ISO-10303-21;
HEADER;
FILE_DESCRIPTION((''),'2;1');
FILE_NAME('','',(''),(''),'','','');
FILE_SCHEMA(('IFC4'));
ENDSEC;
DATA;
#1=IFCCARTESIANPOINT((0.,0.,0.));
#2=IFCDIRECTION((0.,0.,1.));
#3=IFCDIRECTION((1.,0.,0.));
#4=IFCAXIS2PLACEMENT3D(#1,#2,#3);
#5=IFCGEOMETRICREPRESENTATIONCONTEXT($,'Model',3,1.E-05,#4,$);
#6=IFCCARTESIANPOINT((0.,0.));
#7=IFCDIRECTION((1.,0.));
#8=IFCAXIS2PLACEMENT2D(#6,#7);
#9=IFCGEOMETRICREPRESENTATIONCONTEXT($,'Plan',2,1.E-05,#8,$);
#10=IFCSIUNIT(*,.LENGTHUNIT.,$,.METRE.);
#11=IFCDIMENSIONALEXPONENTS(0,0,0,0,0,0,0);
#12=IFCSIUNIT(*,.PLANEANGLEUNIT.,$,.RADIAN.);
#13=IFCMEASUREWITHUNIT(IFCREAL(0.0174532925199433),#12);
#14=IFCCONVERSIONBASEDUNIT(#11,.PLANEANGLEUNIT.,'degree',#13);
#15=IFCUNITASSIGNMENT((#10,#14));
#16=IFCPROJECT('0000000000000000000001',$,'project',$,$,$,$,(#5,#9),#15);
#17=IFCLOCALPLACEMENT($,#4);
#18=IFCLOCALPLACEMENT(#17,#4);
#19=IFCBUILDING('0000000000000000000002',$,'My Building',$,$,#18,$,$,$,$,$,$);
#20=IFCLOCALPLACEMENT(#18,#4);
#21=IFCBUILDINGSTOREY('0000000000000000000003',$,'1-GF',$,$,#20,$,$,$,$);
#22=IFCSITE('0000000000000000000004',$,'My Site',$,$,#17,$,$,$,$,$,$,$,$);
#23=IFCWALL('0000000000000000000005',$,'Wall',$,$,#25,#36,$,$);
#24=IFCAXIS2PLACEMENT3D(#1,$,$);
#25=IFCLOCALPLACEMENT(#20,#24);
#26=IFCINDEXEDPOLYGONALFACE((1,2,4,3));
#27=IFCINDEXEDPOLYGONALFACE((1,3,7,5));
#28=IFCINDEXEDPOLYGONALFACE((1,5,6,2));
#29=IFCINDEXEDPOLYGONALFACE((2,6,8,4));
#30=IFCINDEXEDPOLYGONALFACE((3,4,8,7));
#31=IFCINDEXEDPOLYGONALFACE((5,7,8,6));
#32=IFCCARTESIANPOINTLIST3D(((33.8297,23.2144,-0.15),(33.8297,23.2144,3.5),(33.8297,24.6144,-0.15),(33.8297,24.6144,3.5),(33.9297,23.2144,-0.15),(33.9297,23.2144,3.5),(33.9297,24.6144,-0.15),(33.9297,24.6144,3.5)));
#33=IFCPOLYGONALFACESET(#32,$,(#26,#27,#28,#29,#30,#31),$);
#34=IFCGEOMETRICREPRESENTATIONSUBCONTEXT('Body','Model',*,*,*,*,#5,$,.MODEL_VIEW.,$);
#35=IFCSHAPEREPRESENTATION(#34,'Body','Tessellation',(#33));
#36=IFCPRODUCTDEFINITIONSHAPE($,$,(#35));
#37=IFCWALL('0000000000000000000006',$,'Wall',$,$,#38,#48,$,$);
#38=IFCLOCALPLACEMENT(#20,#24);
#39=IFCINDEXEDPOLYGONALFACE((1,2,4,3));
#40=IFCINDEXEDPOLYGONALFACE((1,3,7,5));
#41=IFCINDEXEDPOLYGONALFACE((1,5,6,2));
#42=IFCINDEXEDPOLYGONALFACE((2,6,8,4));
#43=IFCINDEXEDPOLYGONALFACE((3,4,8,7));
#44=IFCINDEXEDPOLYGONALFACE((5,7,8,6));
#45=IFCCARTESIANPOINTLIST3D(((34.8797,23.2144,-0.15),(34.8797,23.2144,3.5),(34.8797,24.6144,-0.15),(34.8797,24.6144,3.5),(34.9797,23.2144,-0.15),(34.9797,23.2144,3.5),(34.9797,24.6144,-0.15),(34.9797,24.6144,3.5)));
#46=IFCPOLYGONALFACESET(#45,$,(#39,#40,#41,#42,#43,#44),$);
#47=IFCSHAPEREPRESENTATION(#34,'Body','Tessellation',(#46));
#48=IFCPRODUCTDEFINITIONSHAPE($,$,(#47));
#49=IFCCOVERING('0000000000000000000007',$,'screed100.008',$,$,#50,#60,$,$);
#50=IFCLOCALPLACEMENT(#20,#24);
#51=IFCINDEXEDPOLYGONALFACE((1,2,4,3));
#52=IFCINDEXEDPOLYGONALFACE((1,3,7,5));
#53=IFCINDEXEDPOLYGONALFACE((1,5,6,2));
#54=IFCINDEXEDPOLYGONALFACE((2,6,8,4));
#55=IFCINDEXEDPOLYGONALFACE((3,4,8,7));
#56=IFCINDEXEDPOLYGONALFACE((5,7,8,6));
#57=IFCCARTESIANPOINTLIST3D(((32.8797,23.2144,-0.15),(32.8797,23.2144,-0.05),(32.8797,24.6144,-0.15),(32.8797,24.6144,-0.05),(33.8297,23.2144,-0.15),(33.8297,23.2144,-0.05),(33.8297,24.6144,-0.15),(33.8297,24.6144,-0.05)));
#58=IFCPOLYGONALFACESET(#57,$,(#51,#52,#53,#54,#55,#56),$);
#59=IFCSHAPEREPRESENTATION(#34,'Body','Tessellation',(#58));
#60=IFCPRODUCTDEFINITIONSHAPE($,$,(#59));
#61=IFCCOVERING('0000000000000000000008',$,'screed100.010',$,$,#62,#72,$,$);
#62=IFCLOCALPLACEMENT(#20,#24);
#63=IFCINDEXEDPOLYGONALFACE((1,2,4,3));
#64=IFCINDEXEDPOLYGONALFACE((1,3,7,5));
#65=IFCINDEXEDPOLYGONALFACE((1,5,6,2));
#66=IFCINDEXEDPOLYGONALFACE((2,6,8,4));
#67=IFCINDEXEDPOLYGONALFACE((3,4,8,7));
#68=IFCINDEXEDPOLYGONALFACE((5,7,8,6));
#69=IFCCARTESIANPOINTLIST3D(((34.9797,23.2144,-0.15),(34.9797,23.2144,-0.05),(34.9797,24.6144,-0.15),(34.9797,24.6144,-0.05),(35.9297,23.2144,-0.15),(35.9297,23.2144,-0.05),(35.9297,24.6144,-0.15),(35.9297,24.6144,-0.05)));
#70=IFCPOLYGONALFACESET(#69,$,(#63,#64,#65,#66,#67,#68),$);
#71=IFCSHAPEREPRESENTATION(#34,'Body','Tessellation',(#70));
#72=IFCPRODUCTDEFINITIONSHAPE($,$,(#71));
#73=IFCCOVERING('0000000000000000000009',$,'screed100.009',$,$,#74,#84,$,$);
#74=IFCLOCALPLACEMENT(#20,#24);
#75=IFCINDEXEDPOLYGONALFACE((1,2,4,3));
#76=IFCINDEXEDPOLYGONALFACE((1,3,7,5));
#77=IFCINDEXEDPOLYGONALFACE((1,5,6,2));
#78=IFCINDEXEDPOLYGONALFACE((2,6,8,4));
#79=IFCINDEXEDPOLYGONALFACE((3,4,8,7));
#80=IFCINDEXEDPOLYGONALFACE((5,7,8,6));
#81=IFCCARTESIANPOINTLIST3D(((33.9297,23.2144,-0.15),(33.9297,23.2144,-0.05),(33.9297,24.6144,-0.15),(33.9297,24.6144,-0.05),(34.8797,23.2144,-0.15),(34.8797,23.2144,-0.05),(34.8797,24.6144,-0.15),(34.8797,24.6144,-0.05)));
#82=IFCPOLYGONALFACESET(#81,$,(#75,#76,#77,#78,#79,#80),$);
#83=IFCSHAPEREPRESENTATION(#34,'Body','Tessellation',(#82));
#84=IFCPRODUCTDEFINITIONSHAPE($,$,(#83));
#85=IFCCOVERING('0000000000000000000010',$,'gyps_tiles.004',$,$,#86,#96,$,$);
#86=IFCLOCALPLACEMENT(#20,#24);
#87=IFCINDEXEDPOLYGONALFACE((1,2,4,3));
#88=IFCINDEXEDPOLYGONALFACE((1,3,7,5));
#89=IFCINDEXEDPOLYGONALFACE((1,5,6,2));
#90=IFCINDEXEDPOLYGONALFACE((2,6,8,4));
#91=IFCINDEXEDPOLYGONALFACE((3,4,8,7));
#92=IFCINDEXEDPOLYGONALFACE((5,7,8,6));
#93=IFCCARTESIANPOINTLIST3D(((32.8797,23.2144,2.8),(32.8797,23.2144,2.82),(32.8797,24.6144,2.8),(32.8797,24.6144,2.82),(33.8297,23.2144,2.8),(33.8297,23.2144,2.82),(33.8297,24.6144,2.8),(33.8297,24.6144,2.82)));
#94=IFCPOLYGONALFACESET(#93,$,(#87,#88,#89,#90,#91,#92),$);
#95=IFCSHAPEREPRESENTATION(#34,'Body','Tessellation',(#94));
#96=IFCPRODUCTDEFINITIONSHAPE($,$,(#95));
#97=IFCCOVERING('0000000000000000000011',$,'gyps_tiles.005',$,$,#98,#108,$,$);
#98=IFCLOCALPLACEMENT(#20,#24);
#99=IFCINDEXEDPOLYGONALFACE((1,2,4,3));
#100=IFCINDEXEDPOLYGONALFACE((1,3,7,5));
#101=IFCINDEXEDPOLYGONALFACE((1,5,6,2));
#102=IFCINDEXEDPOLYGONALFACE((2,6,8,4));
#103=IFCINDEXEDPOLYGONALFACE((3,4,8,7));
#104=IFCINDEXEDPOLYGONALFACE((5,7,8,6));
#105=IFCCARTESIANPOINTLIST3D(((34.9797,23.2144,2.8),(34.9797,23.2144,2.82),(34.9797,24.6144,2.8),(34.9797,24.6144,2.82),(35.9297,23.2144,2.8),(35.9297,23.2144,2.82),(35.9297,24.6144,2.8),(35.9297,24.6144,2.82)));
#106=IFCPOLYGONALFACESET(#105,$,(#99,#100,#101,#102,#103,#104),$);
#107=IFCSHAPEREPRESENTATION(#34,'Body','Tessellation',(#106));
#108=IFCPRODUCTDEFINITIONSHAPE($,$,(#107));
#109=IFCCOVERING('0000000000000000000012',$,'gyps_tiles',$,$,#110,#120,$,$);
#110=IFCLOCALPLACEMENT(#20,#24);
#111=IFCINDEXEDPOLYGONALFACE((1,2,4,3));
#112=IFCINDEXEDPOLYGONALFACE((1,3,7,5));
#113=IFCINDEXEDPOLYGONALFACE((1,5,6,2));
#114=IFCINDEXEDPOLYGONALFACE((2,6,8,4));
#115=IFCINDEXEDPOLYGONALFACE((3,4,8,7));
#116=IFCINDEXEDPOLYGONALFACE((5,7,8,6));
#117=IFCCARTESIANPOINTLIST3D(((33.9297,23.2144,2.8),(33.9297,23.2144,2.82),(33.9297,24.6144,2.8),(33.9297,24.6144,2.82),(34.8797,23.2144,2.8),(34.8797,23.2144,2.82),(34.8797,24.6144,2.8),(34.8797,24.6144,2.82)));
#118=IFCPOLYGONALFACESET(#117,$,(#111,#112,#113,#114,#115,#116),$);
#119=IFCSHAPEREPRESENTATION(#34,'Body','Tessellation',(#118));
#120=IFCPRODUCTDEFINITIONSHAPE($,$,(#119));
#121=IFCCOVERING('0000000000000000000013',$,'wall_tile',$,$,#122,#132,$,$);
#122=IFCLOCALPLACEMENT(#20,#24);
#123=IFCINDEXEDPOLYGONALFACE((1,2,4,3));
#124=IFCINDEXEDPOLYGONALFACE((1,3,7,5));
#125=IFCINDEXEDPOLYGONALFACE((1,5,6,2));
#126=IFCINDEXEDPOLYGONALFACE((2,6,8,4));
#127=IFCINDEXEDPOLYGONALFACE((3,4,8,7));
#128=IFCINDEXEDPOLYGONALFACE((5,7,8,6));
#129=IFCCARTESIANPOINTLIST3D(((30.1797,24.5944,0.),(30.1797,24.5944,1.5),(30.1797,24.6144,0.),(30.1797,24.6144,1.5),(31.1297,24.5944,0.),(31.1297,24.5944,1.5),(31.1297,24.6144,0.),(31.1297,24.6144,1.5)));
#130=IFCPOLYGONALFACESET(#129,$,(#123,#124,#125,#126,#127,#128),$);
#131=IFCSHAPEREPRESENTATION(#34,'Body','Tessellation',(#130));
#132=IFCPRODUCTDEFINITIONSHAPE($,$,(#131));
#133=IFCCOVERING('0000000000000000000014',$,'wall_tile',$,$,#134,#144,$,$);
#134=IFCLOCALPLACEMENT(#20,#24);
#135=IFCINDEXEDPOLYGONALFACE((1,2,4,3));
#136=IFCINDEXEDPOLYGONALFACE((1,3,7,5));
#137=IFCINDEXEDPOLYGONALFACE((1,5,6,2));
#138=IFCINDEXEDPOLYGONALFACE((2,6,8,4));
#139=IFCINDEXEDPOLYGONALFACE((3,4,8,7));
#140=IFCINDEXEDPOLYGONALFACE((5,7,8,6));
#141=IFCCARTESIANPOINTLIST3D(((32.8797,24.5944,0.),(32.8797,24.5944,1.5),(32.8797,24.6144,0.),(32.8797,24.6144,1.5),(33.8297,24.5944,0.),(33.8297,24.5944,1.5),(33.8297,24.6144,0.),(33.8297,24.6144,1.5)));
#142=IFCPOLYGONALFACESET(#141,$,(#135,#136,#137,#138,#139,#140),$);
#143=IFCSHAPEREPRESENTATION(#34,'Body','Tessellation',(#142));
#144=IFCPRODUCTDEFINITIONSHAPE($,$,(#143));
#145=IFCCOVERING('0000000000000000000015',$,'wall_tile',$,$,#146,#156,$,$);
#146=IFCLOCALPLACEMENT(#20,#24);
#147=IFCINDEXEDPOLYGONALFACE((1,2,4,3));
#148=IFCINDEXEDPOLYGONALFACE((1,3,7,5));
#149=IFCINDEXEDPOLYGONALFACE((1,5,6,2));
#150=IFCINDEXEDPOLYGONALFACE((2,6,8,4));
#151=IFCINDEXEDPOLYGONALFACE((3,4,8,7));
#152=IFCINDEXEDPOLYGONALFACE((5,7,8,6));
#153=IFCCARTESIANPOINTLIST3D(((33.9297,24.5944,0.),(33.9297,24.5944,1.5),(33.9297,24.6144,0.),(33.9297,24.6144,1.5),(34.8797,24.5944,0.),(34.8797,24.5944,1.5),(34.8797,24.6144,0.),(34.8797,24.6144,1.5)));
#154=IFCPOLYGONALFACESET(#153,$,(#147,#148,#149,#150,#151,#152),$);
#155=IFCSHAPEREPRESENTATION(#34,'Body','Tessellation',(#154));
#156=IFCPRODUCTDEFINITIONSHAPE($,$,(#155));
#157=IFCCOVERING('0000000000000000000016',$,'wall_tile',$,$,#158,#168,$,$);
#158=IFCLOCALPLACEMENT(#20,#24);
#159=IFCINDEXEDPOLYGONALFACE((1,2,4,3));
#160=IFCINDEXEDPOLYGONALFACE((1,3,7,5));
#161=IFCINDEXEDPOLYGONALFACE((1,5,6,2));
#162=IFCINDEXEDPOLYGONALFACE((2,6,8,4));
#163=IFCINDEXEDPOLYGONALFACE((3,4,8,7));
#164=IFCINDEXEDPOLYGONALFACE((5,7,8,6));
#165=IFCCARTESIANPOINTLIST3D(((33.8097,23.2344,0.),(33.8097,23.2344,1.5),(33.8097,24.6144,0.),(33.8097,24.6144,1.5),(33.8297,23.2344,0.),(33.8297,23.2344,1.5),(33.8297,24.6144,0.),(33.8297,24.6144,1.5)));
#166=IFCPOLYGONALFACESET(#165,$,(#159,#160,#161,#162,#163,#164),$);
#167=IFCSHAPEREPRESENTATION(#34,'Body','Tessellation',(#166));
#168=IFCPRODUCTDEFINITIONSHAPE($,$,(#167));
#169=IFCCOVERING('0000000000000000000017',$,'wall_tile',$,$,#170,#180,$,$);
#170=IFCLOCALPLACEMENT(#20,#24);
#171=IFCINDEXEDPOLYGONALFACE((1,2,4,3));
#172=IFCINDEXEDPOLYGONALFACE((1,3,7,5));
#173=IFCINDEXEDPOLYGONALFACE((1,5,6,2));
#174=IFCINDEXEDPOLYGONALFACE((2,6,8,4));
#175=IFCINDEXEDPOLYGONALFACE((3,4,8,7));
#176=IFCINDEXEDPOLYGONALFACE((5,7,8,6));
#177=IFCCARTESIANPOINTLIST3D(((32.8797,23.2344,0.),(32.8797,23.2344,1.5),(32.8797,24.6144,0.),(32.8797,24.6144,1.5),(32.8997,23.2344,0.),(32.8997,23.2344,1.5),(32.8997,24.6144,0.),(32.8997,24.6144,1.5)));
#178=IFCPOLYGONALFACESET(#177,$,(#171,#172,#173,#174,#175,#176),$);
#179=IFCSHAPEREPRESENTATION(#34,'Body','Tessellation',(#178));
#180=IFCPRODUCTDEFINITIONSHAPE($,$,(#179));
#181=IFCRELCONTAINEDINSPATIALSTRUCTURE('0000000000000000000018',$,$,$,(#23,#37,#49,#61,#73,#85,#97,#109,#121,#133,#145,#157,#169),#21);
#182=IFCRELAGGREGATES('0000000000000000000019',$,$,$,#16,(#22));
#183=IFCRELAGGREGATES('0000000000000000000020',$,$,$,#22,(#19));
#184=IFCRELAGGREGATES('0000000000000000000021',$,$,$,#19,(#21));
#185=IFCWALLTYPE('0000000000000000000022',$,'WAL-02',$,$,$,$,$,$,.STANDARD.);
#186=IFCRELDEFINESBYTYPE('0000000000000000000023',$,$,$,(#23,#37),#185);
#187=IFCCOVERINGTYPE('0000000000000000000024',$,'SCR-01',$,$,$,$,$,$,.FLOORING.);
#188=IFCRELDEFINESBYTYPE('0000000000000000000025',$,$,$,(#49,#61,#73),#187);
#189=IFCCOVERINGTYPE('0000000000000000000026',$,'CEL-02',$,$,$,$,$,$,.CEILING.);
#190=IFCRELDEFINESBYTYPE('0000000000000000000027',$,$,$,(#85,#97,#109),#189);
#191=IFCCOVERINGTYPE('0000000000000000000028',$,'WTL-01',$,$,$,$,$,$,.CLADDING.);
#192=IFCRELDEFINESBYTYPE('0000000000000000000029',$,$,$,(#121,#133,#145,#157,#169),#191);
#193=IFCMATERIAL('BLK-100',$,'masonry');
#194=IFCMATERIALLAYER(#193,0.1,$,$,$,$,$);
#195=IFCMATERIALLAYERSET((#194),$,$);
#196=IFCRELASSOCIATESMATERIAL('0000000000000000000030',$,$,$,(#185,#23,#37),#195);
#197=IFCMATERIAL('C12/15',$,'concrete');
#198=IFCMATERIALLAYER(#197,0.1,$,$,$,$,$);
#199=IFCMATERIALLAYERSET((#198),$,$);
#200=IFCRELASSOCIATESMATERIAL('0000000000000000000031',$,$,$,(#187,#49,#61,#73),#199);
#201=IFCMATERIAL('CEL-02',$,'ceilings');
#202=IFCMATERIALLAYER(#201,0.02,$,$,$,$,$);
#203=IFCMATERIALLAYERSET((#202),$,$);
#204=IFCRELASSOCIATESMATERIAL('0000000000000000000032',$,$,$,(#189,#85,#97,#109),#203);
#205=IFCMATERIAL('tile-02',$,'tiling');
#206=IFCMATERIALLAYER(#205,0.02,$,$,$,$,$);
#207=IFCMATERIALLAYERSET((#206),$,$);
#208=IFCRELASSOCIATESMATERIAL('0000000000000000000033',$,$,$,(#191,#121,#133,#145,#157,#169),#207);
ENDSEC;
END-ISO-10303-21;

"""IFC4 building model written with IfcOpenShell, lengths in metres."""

from ifc_helpers import new_model, entity, si_unit, converted_unit, frame, origin_with_axes, origin_2d_with_axis, place, context, subcontext, project, spatial, line, indexed_curve, outline, extrude, material, layer, layer_set, layer_usage, type_object, element, save


model = new_model("IFC4")

# Units and contexts
model_context = context("Model", 3, precision=1e-05, world=origin_with_axes())
plan_context = context("Plan", 2, precision=1e-05, world=origin_2d_with_axis())
body_context_1 = subcontext(model_context, "Body", "Model", "MODEL_VIEW")
ifc_project = project(units=[si_unit("LENGTHUNIT", "METRE"), converted_unit("PLANEANGLEUNIT", "degree", entity("IfcReal", 0.0174532925199433), si_unit("PLANEANGLEUNIT", "RADIAN"), dimensions=[0, 0, 0, 0, 0, 0, 0])], contexts=[model_context, plan_context])

# Site, building, storey
site_placement = place(None, origin_with_axes())
site = spatial("IfcSite", under=ifc_project, at=site_placement, Name="My Site")
building_placement = place(site_placement, origin_with_axes())
building = spatial("IfcBuilding", under=site, at=building_placement, Name="My Building")
storey_placement = place(building_placement, origin_with_axes())
storey = spatial("IfcBuildingStorey", under=building, at=storey_placement, Name="1-GF")

# Shared definitions
ifc_material_1 = material(Name="BLK-100", Category="masonry")
ifc_layer_1 = layer(ifc_material_1, 0.1)
ifc_layer_set_1 = layer_set([ifc_layer_1])
wall_type = type_object("IfcWallType", Name="WAL-02", PredefinedType="STANDARD", material=ifc_layer_set_1)

# Walls
ifc_layer_usage_1 = layer_usage(ifc_layer_set_1, "AXIS2", "POSITIVE", 0.0)
wall_1_placement = place(storey_placement, frame((33.9297, 23.2144, -0.15), z_axis=(0.0, 0.0, 1.0), x_axis=(0.0, 1.0, 0.0)))
element("IfcWall", 1, at=wall_1_placement, inside=storey, type_object=wall_type, material=ifc_layer_usage_1, Name="Wall", context=body_context_1, shape_type="SweptSolid", body=[
    extrude(outline(indexed_curve([(0.0, 0.0), (0.0, 0.1), (1.4, 0.1), (1.4, 0.0), (0.0, 0.0)], self_intersect=False)), origin_with_axes(), (0.0, 0.0, 1.0), 3.65),
])
ifc_layer_usage_2 = layer_usage(ifc_layer_set_1, "AXIS2", "POSITIVE", 0.0)
wall_2_placement = place(storey_placement, frame((34.9797, 23.2144, -0.15), z_axis=(0.0, 0.0, 1.0), x_axis=(0.0, 1.0, 0.0)))
element("IfcWall", 2, at=wall_2_placement, inside=storey, type_object=wall_type, material=ifc_layer_usage_2, Name="Wall", context=body_context_1, shape_type="SweptSolid", body=[
    extrude(outline(indexed_curve([(0.0, 0.0), (0.0, 0.1), (1.4, 0.1), (1.4, 0.0), (0.0, 0.0)], self_intersect=False)), origin_with_axes(), (0.0, 0.0, 1.0), 3.65),
])

# Coverings
ifc_material_2 = material(Name="C12/15", Category="concrete")
ifc_layer_2 = layer(ifc_material_2, 0.1)
ifc_layer_set_2 = layer_set([ifc_layer_2])
covering_type_1 = type_object("IfcCoveringType", Name="SCR-01", PredefinedType="FLOORING", material=ifc_layer_set_2)
ifc_layer_usage_3 = layer_usage(ifc_layer_set_2, "AXIS3", "POSITIVE", 0.0)
covering_1_placement = place(storey_placement, frame((32.8797, 23.2144, -0.15), z_axis=(0.0, 0.0, 1.0), x_axis=(1.0, 0.0, 0.0)))
element("IfcCovering", 3, at=covering_1_placement, inside=storey, type_object=covering_type_1, material=ifc_layer_usage_3, Name="screed100.008", context=body_context_1, shape_type="SweptSolid", body=[
    extrude(outline(indexed_curve([(0.0, 0.0), (0.95, 0.0), (0.95, 1.4), (0.0, 1.4)], segments=[line(4, 1), line(1, 2), line(2, 3), line(3, 4)], self_intersect=False)), None, (0.0, 0.0, 1.0), 0.1),
])
ifc_layer_usage_4 = layer_usage(ifc_layer_set_2, "AXIS3", "POSITIVE", 0.0)
covering_2_placement = place(storey_placement, frame((34.9797, 23.2144, -0.15), z_axis=(0.0, 0.0, 1.0), x_axis=(1.0, 0.0, 0.0)))
element("IfcCovering", 4, at=covering_2_placement, inside=storey, type_object=covering_type_1, material=ifc_layer_usage_4, Name="screed100.010", context=body_context_1, shape_type="SweptSolid", body=[
    extrude(outline(indexed_curve([(0.0, 0.0), (0.95, 0.0), (0.95, 1.4), (0.0, 1.4)], segments=[line(4, 1), line(1, 2), line(2, 3), line(3, 4)], self_intersect=False)), None, (0.0, 0.0, 1.0), 0.1),
])
ifc_layer_usage_5 = layer_usage(ifc_layer_set_2, "AXIS3", "POSITIVE", 0.0)
covering_3_placement = place(storey_placement, frame((33.9297, 23.2144, -0.15), z_axis=(0.0, 0.0, 1.0), x_axis=(1.0, 0.0, 0.0)))
element("IfcCovering", 5, at=covering_3_placement, inside=storey, type_object=covering_type_1, material=ifc_layer_usage_5, Name="screed100.009", context=body_context_1, shape_type="SweptSolid", body=[
    extrude(outline(indexed_curve([(0.0, 0.0), (0.95, 0.0), (0.95, 1.4), (0.0, 1.4)], segments=[line(4, 1), line(1, 2), line(2, 3), line(3, 4)], self_intersect=False)), None, (0.0, 0.0, 1.0), 0.1),
])
ifc_material_3 = material(Name="CEL-02", Category="ceilings")
ifc_layer_3 = layer(ifc_material_3, 0.02)
ifc_layer_set_3 = layer_set([ifc_layer_3])
ifc_layer_usage_6 = layer_usage(ifc_layer_set_3, "AXIS3", "POSITIVE", 0.0)
covering_type_2 = type_object("IfcCoveringType", Name="CEL-02", PredefinedType="CEILING", material=ifc_layer_set_3)
covering_4_placement = place(storey_placement, frame((32.8797, 23.2144, 2.8), z_axis=(0.0, 0.0, 1.0), x_axis=(1.0, 0.0, 0.0)))
element("IfcCovering", 6, at=covering_4_placement, inside=storey, type_object=covering_type_2, material=ifc_layer_usage_6, Name="gyps_tiles.004", context=body_context_1, shape_type="SweptSolid", body=[
    extrude(outline(indexed_curve([(0.0, 0.0), (0.95, 0.0), (0.95, 1.4), (0.0, 1.4)], segments=[line(4, 1), line(1, 2), line(2, 3), line(3, 4)], self_intersect=False)), None, (0.0, 0.0, 1.0), 0.02),
])
ifc_layer_usage_7 = layer_usage(ifc_layer_set_3, "AXIS3", "POSITIVE", 0.0)
covering_5_placement = place(storey_placement, frame((34.9797, 23.2144, 2.8), z_axis=(0.0, 0.0, 1.0), x_axis=(1.0, 0.0, 0.0)))
element("IfcCovering", 7, at=covering_5_placement, inside=storey, type_object=covering_type_2, material=ifc_layer_usage_7, Name="gyps_tiles.005", context=body_context_1, shape_type="SweptSolid", body=[
    extrude(outline(indexed_curve([(0.0, 0.0), (0.95, 0.0), (0.95, 1.4), (0.0, 1.4)], segments=[line(4, 1), line(1, 2), line(2, 3), line(3, 4)], self_intersect=False)), None, (0.0, 0.0, 1.0), 0.02),
])
ifc_layer_usage_8 = layer_usage(ifc_layer_set_3, "AXIS3", "POSITIVE", 0.0)
covering_6_placement = place(storey_placement, frame((33.9297, 23.2144, 2.8), z_axis=(0.0, 0.0, 1.0), x_axis=(1.0, 0.0, 0.0)))
element("IfcCovering", 8, at=covering_6_placement, inside=storey, type_object=covering_type_2, material=ifc_layer_usage_8, Name="gyps_tiles", context=body_context_1, shape_type="SweptSolid", body=[
    extrude(outline(indexed_curve([(0.0, 0.0), (0.95, 0.0), (0.95, 1.4), (0.0, 1.4)], segments=[line(4, 1), line(1, 2), line(2, 3), line(3, 4)], self_intersect=False)), None, (0.0, 0.0, 1.0), 0.02),
])
ifc_material_4 = material(Name="tile-02", Category="tiling")
ifc_layer_4 = layer(ifc_material_4, 0.02)
ifc_layer_set_4 = layer_set([ifc_layer_4])
ifc_layer_usage_9 = layer_usage(ifc_layer_set_4, "AXIS2", "POSITIVE", 0.0)
covering_type_3 = type_object("IfcCoveringType", Name="WTL-01", PredefinedType="CLADDING", material=ifc_layer_set_4)
covering_7_placement = place(storey_placement, frame((31.1297, 24.6144, 0.0), z_axis=(0.0, 0.0, 1.0), x_axis=(-1.0, 0.000001, 0.0)))
element("IfcCovering", 9, at=covering_7_placement, inside=storey, type_object=covering_type_3, material=ifc_layer_usage_9, Name="wall_tile", context=body_context_1, shape_type="SweptSolid", body=[
    extrude(outline(indexed_curve([(0.0, 0.0), (0.0, 0.02), (0.95, 0.02), (0.95, 0.0), (0.0, 0.0)], self_intersect=False)), origin_with_axes(), (0.0, 0.0, 1.0), 1.5),
])
ifc_layer_usage_10 = layer_usage(ifc_layer_set_4, "AXIS2", "POSITIVE", 0.0)
covering_8_placement = place(storey_placement, frame((33.8297, 24.6144, 0.0), z_axis=(0.0, 0.0, 1.0), x_axis=(-1.0, 0.000001, 0.0)))
element("IfcCovering", 10, at=covering_8_placement, inside=storey, type_object=covering_type_3, material=ifc_layer_usage_10, Name="wall_tile", context=body_context_1, shape_type="SweptSolid", body=[
    extrude(outline(indexed_curve([(0.0, 0.0), (0.0, 0.02), (0.95, 0.02), (0.95, 0.0), (0.0, 0.0)], self_intersect=False)), origin_with_axes(), (0.0, 0.0, 1.0), 1.5),
])
ifc_layer_usage_11 = layer_usage(ifc_layer_set_4, "AXIS2", "POSITIVE", 0.0)
covering_9_placement = place(storey_placement, frame((34.8797, 24.6144, 0.0), z_axis=(0.0, 0.0, 1.0), x_axis=(-1.0, 0.000001, 0.0)))
element("IfcCovering", 11, at=covering_9_placement, inside=storey, type_object=covering_type_3, material=ifc_layer_usage_11, Name="wall_tile", context=body_context_1, shape_type="SweptSolid", body=[
    extrude(outline(indexed_curve([(0.0, 0.0), (0.0, 0.02), (0.95, 0.02), (0.95, 0.0), (0.0, 0.0)], self_intersect=False)), origin_with_axes(), (0.0, 0.0, 1.0), 1.5),
])
ifc_layer_usage_12 = layer_usage(ifc_layer_set_4, "AXIS2", "POSITIVE", 0.0)
covering_10_placement = place(storey_placement, frame((33.8297, 23.2344, 0.0), z_axis=(0.0, 0.0, 1.0), x_axis=(0.000001, 1.0, 0.0)))
element("IfcCovering", 12, at=covering_10_placement, inside=storey, type_object=covering_type_3, material=ifc_layer_usage_12, Name="wall_tile", context=body_context_1, shape_type="SweptSolid", body=[
    extrude(outline(indexed_curve([(0.0, 0.0), (0.0, 0.02), (1.38, 0.02), (1.38, 0.0), (0.0, 0.0)], self_intersect=False)), origin_with_axes(), (0.0, 0.0, 1.0), 1.5),
])
ifc_layer_usage_13 = layer_usage(ifc_layer_set_4, "AXIS2", "POSITIVE", 0.0)
covering_11_placement = place(storey_placement, frame((32.8997, 23.2344, 0.0), z_axis=(0.0, 0.0, 1.0), x_axis=(0.000001, 1.0, 0.0)))
element("IfcCovering", 13, at=covering_11_placement, inside=storey, type_object=covering_type_3, material=ifc_layer_usage_13, Name="wall_tile", context=body_context_1, shape_type="SweptSolid", body=[
    extrude(outline(indexed_curve([(0.0, 0.0), (0.0, 0.02), (1.38, 0.02), (1.38, 0.0), (0.0, 0.0)], self_intersect=False)), origin_with_axes(), (0.0, 0.0, 1.0), 1.5),
])

save(model, "model.ifc")
